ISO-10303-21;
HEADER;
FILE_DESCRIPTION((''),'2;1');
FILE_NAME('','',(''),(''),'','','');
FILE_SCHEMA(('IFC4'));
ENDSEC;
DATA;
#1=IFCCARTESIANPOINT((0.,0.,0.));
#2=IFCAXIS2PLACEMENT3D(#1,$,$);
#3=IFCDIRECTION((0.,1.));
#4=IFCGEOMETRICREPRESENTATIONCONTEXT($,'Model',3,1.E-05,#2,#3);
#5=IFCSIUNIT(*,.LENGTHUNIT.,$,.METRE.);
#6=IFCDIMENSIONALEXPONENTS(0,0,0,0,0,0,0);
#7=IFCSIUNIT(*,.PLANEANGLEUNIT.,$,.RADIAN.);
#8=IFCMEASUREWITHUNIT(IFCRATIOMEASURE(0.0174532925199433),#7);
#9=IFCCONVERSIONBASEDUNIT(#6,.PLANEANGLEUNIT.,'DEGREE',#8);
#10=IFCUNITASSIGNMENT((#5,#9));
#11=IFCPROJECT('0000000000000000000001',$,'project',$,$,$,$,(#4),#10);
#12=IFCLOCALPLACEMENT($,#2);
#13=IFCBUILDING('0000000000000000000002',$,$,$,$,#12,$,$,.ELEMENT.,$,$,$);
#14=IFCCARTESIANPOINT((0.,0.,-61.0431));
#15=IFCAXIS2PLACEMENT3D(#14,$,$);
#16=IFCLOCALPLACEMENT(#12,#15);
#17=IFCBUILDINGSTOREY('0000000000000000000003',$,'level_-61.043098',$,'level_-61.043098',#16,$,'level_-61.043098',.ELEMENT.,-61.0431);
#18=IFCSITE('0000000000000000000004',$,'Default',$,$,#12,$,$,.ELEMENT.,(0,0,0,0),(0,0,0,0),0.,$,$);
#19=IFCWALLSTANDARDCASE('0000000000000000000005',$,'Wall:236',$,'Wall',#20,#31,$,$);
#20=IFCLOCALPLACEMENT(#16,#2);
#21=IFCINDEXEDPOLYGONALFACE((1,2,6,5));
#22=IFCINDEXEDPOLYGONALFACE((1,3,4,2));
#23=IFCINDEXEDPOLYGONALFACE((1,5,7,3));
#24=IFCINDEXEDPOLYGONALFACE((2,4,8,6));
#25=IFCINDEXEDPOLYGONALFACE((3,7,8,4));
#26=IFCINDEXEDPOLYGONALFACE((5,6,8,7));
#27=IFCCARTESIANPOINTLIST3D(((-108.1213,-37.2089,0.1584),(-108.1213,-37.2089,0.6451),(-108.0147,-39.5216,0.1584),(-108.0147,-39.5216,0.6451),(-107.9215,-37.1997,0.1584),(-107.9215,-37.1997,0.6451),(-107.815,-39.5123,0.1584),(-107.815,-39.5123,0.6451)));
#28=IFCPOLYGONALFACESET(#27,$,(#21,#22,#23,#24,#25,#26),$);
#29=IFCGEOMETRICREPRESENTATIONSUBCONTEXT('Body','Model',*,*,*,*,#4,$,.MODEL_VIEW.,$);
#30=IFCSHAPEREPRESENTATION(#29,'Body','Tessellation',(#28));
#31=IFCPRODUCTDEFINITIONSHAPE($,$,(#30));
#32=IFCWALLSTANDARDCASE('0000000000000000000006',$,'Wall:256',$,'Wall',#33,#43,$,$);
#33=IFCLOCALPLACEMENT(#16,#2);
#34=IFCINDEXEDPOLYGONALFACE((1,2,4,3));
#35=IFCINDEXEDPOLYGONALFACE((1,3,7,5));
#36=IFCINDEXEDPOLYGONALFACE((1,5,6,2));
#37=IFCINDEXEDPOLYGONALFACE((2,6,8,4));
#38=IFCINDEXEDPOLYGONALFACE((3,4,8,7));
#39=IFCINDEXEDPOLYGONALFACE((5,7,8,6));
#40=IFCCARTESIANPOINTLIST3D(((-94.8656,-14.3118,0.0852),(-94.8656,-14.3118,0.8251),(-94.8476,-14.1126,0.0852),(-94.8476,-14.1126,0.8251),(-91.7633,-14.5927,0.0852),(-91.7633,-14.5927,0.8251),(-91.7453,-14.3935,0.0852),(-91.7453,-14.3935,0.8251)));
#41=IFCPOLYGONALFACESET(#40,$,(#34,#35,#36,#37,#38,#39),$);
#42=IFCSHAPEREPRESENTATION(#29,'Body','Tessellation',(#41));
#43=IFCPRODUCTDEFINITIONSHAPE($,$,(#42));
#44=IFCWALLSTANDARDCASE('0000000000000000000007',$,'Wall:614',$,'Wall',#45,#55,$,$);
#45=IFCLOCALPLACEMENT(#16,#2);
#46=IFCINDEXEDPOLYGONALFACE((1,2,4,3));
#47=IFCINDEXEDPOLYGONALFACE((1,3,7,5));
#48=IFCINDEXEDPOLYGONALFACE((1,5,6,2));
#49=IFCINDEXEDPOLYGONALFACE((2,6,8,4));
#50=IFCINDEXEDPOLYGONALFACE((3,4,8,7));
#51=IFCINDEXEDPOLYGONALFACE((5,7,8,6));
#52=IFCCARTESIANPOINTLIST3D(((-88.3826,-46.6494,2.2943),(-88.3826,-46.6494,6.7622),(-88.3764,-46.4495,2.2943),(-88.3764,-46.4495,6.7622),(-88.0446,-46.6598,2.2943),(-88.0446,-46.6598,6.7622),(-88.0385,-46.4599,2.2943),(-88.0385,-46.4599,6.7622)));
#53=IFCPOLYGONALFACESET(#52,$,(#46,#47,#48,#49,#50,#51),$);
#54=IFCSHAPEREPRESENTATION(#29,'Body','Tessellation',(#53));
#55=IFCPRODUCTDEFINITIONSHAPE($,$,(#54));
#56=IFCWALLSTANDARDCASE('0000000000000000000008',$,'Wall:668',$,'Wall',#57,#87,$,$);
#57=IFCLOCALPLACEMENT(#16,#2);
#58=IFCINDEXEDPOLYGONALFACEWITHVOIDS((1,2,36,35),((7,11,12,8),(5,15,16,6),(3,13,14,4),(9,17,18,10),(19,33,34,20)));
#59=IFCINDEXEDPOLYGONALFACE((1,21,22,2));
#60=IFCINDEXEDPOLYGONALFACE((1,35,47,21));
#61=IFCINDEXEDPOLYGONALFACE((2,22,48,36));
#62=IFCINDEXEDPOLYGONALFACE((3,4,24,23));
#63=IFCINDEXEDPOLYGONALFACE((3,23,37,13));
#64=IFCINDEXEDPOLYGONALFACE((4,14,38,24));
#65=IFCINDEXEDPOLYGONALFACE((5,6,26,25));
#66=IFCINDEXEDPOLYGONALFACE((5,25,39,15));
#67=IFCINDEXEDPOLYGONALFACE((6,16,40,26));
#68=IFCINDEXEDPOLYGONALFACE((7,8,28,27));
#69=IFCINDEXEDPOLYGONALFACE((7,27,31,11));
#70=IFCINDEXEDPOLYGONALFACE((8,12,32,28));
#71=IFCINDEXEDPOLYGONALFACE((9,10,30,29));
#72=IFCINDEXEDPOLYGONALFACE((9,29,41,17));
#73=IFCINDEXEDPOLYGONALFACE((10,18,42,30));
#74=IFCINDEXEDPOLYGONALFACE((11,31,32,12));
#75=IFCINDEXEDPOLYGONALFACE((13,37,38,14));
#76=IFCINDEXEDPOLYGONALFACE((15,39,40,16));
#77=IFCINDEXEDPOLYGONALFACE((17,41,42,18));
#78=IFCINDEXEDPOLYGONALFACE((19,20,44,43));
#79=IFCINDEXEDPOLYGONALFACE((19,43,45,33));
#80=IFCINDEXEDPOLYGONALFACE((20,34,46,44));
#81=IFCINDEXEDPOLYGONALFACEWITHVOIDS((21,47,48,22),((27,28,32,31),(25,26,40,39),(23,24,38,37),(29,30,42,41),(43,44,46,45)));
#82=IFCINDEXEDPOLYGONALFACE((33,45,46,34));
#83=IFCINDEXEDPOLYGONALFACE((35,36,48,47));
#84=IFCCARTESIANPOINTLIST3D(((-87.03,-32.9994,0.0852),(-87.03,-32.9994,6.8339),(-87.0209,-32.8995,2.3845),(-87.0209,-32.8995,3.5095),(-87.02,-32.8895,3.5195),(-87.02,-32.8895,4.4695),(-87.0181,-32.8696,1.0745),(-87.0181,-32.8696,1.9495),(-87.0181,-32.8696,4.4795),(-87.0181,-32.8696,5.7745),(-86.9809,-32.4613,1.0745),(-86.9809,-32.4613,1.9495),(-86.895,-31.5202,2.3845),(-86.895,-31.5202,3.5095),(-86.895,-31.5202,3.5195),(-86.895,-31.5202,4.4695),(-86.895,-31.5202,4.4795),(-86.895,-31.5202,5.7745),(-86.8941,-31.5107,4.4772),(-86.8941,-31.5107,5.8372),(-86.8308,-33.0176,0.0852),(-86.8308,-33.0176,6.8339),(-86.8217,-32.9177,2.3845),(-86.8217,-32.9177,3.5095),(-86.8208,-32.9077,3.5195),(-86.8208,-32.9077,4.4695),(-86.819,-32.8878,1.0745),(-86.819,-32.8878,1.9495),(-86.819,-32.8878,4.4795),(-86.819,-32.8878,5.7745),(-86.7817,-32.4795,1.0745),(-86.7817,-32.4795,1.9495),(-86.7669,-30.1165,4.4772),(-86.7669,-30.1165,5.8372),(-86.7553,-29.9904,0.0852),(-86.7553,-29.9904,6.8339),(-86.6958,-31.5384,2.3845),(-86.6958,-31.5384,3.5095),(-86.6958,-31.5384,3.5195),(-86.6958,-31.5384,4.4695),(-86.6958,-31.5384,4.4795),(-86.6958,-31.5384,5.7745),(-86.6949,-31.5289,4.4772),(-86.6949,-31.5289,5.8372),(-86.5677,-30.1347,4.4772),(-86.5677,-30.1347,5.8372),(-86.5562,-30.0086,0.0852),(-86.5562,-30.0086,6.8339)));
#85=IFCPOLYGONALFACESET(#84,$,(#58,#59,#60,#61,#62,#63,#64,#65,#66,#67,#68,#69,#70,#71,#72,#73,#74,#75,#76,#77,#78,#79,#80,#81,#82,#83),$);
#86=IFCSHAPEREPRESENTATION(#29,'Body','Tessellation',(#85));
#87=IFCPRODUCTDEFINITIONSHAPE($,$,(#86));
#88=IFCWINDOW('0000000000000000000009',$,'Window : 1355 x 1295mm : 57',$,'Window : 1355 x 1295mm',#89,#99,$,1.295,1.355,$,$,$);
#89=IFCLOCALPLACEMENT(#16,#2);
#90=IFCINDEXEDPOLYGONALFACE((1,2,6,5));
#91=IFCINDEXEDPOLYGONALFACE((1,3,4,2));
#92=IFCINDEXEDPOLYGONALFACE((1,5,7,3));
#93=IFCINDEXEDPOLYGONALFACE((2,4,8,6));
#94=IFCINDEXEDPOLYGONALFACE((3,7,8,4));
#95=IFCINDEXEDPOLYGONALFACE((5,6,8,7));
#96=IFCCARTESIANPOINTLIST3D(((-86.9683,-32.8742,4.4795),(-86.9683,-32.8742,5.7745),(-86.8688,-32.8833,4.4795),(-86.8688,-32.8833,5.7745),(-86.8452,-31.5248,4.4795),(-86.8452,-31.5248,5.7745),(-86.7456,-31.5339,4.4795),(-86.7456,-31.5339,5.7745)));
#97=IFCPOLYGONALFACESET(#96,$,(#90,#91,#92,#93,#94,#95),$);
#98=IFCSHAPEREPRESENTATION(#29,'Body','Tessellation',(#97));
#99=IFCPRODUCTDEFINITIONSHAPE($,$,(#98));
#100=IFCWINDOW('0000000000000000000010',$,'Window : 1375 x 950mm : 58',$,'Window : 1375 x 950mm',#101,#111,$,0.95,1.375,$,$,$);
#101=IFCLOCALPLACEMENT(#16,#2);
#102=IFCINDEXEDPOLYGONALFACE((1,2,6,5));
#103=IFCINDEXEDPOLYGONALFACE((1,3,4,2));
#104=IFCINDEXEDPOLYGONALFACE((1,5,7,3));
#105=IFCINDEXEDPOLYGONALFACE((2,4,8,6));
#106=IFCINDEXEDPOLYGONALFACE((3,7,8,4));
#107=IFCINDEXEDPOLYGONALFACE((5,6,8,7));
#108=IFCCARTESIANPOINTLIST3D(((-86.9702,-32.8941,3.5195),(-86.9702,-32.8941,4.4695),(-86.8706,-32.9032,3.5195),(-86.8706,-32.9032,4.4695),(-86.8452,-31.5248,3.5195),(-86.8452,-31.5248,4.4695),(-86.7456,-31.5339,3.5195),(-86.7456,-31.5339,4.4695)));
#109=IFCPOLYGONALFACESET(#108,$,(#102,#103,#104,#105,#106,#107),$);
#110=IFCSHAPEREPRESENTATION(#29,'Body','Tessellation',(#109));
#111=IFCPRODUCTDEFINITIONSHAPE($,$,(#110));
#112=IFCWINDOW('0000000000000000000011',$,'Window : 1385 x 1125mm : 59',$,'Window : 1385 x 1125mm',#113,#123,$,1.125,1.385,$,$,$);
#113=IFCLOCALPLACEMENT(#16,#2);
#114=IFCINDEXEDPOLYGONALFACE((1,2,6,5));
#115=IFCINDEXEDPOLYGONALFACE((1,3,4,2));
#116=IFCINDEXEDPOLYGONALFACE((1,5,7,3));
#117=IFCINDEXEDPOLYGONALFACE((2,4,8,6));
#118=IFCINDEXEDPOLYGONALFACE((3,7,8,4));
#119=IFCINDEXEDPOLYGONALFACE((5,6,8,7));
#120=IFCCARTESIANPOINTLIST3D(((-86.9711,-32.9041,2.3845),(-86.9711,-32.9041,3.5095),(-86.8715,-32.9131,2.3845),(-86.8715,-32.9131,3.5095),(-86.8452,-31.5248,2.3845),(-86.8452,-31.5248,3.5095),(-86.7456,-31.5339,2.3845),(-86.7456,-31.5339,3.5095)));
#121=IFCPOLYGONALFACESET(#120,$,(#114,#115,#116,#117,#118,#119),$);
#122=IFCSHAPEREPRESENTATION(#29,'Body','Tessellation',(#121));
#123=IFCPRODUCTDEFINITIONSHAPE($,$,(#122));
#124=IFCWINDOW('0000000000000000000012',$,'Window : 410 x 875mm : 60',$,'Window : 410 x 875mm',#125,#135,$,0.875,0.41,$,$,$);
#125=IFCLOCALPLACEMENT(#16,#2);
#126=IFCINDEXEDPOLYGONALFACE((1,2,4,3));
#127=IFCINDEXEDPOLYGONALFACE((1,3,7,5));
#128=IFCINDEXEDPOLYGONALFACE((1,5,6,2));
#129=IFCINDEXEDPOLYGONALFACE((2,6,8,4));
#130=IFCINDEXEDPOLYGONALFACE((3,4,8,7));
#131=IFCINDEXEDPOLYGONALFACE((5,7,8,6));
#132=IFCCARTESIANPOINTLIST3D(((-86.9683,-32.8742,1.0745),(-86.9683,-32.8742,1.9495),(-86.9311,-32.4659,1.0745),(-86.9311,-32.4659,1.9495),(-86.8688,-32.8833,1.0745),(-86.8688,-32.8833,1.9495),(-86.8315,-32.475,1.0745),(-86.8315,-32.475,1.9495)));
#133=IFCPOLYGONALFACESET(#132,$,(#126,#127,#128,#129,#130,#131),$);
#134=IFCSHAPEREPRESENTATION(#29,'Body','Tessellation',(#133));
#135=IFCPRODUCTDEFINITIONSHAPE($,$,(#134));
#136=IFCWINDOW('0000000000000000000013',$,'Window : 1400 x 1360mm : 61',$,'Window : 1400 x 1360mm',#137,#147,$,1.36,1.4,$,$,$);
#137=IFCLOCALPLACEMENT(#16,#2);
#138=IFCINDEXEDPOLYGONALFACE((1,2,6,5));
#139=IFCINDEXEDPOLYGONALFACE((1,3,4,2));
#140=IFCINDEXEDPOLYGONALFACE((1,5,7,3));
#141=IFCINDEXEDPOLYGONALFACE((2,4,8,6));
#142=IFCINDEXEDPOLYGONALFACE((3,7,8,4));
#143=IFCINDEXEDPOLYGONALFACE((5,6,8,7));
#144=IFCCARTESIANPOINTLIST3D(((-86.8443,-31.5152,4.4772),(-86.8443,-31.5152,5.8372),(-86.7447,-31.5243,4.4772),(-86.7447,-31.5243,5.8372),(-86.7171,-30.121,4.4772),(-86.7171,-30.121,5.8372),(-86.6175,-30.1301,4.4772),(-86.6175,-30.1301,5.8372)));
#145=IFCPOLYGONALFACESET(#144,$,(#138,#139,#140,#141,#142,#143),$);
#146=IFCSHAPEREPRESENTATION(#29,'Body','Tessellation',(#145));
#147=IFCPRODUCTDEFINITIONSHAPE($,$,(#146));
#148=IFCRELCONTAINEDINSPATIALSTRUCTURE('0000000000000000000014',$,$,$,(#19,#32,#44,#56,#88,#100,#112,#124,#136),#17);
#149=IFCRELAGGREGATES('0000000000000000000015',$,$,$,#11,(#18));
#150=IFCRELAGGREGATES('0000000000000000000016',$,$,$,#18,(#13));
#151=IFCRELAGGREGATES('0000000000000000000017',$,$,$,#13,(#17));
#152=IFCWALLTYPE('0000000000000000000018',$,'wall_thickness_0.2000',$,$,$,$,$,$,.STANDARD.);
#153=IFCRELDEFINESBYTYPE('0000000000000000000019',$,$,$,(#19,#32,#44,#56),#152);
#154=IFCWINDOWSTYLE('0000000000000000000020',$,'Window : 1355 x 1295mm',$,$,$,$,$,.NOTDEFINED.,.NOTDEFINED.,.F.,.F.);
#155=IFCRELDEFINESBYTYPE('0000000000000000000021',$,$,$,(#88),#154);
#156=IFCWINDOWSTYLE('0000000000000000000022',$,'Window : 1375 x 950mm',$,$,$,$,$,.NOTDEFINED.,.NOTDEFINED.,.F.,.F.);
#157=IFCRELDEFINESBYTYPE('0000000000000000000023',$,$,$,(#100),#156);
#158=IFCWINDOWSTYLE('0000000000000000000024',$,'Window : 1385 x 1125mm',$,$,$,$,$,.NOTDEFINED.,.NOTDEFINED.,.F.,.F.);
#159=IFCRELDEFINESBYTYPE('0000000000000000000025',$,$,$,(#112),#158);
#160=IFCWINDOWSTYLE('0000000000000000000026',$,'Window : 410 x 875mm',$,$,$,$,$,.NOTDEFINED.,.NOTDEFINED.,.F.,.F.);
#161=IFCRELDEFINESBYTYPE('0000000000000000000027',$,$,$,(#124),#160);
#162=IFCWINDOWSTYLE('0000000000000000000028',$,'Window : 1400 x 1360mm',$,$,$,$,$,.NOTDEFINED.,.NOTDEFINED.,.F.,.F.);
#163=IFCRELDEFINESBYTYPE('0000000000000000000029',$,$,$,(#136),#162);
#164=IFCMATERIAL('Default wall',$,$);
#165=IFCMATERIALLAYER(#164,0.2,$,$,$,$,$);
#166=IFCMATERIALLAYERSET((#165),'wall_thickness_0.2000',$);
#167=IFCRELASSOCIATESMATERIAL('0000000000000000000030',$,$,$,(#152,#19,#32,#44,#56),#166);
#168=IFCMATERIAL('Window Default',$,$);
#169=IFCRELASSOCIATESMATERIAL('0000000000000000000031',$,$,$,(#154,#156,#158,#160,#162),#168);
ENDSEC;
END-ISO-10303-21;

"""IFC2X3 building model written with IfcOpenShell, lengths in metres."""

from ifc_helpers import new_model, entity, si_unit, converted_unit, direction, frame, frame_2d, origin, origin_2d_with_axis, place, context, subcontext, project, spatial, polyline, rectangle, outline, extrude, source, transform, mapped, material, layer, layer_set, layer_usage, type_object, type_shapes, element, fill, save


model = new_model("IFC2X3")

# Units and contexts
model_context = context("Model", 3, precision=1e-05, world=origin(), true_north=direction((0.0, 1.0)))
body_context = subcontext(model_context, "Body", "Model", "MODEL_VIEW")
ifc_project = project(units=[si_unit("LENGTHUNIT", "METRE"), converted_unit("PLANEANGLEUNIT", "DEGREE", entity("IfcRatioMeasure", 0.0174532925199433), si_unit("PLANEANGLEUNIT", "RADIAN"), dimensions=[0, 0, 0, 0, 0, 0, 0])], contexts=[model_context])

# Site, building, storey
placement_1 = place(None, origin())
site = spatial("IfcSite", under=ifc_project, at=placement_1, Name="Default", CompositionType="ELEMENT", RefLatitude=(0, 0, 0, 0), RefLongitude=(0, 0, 0, 0), RefElevation=0.0)
building = spatial("IfcBuilding", under=site, at=placement_1, CompositionType="ELEMENT")
storey_placement = place(placement_1, frame((0.0, 0.0, -61.0431)))
storey = spatial("IfcBuildingStorey", under=building, at=storey_placement, Name="level_-61.043098", ObjectType="level_-61.043098", LongName="level_-61.043098", CompositionType="ELEMENT", Elevation=-61.0431)

# Walls
ifc_material_1 = material(Name="Default wall")
ifc_layer = layer(ifc_material_1, 0.2)
ifc_layer_set = layer_set([ifc_layer], Name="wall_thickness_0.2000")
ifc_layer_usage = layer_usage(ifc_layer_set, "AXIS2", "POSITIVE", -0.1)
wall_type = type_object("IfcWallType", Name="wall_thickness_0.2000", PredefinedType="STANDARD", material=ifc_layer_set)
placement_2 = place(placement_1, frame((0.0, 0.0, -60.8847)))
wall_1_placement = place(placement_2, frame((-108.0214, -37.2043, 0.0), z_axis=(0.0, 0.0, 1.0), x_axis=(0.046035, -0.99894, 0.0)))
element("IfcWallStandardCase", 1, at=wall_1_placement, inside=storey, type_object=wall_type, material=ifc_layer_usage, Name="Wall:236", ObjectType="Wall", context=body_context, shape_type="SweptSolid", body=[
    extrude(outline(polyline([(2.3151, -0.1), (2.3151, 0.1), (0.0, 0.1), (0.0, -0.1), (2.3151, -0.1)])), origin(), (0.0, 0.0, 1.0), 0.4867),
])
placement_3 = place(placement_1, frame((0.0, 0.0, -60.9579)))
wall_2_placement = place(placement_3, frame((-94.8566, -14.2122, 0.0), z_axis=(0.0, 0.0, 1.0), x_axis=(0.995927, -0.090165, 0.0)))
element("IfcWallStandardCase", 2, at=wall_2_placement, inside=storey, type_object=wall_type, material=ifc_layer_usage, Name="Wall:256", ObjectType="Wall", context=body_context, shape_type="SweptSolid", body=[
    extrude(outline(polyline([(3.115, -0.1), (3.115, 0.1), (0.0, 0.1), (0.0, -0.1), (3.115, -0.1)])), origin(), (0.0, 0.0, 1.0), 0.7399),
])
placement_4 = place(placement_1, frame((0.0, 0.0, -58.7488)))
wall_3_placement = place(placement_4, frame((-88.0415, -46.5599, 0.0), z_axis=(0.0, 0.0, 1.0), x_axis=(-0.999523, 0.030892, 0.0)))
element("IfcWallStandardCase", 3, at=wall_3_placement, inside=storey, type_object=wall_type, material=ifc_layer_usage, Name="Wall:614", ObjectType="Wall", context=body_context, shape_type="SweptSolid", body=[
    extrude(outline(polyline([(0.3381, -0.1), (0.3381, 0.1), (0.0, 0.1), (0.0, -0.1), (0.3381, -0.1)])), origin(), (0.0, 0.0, 1.0), 4.4679),
])

# Wall, openings, windows
placement_5 = place(placement_1, frame((0.0, 0.0, -60.9579)))
wall_4_placement = place(placement_5, frame((-86.6558, -29.9995, 0.0), z_axis=(0.0, 0.0, 1.0), x_axis=(-0.090893, -0.995861, 0.0)))
wall_4 = element("IfcWallStandardCase", 4, at=wall_4_placement, inside=storey, type_object=wall_type, material=ifc_layer_usage, Name="Wall:668", ObjectType="Wall", context=body_context, shape_type="SweptSolid", body=[
    extrude(outline(polyline([(3.0215, -0.1), (3.0215, 0.1), (0.0, 0.1), (0.0, -0.1), (3.0215, -0.1)])), origin(), (0.0, 0.0, 1.0), 6.7487),
])
opening_1_placement = place(wall_4_placement, frame((1.5362, -0.1, 4.3942)))
opening_1 = element("IfcOpeningElement", 5, at=opening_1_placement, cuts=wall_4, ObjectType="Opening", context=body_context, shape_type="SweptSolid", body=[
    extrude(rectangle(XDim=1.355, YDim=1.295, at=frame_2d((0.6475, 0.6775), x_axis=(0.0, 1.0))), frame((0.0, 0.0, 0.0), z_axis=(0.0, 1.0, 0.0), x_axis=(0.0, 0.0, 1.0)), (0.0, 0.0, 1.0), 0.2),
])
opening_2_placement = place(wall_4_placement, frame((1.5362, -0.1, 3.4342)))
opening_2 = element("IfcOpeningElement", 6, at=opening_2_placement, cuts=wall_4, ObjectType="Opening", context=body_context, shape_type="SweptSolid", body=[
    extrude(rectangle(XDim=1.375, YDim=0.95, at=frame_2d((0.475, 0.6875), x_axis=(0.0, 1.0))), frame((0.0, 0.0, 0.0), z_axis=(0.0, 1.0, 0.0), x_axis=(0.0, 0.0, 1.0)), (0.0, 0.0, 1.0), 0.2),
])
opening_3_placement = place(wall_4_placement, frame((1.5362, -0.1, 2.2992)))
opening_3 = element("IfcOpeningElement", 7, at=opening_3_placement, cuts=wall_4, ObjectType="Opening", context=body_context, shape_type="SweptSolid", body=[
    extrude(rectangle(XDim=1.385, YDim=1.125, at=frame_2d((0.5625, 0.6925), x_axis=(0.0, 1.0))), frame((0.0, 0.0, 0.0), z_axis=(0.0, 1.0, 0.0), x_axis=(0.0, 0.0, 1.0)), (0.0, 0.0, 1.0), 0.2),
])
opening_4_placement = place(wall_4_placement, frame((2.4812, -0.1, 0.9892)))
opening_4 = element("IfcOpeningElement", 8, at=opening_4_placement, cuts=wall_4, ObjectType="Opening", context=body_context, shape_type="SweptSolid", body=[
    extrude(rectangle(XDim=0.41, YDim=0.875, at=frame_2d((0.4375, 0.205), x_axis=(0.0, 1.0))), frame((0.0, 0.0, 0.0), z_axis=(0.0, 1.0, 0.0), x_axis=(0.0, 0.0, 1.0)), (0.0, 0.0, 1.0), 0.2),
])
opening_5_placement = place(wall_4_placement, frame((0.1266, -0.1, 4.392)))
opening_5 = element("IfcOpeningElement", 9, at=opening_5_placement, cuts=wall_4, ObjectType="Opening", context=body_context, shape_type="SweptSolid", body=[
    extrude(rectangle(XDim=1.4, YDim=1.36, at=frame_2d((0.68, 0.7), x_axis=(0.0, 1.0))), frame((0.0, 0.0, 0.0), z_axis=(0.0, 1.0, 0.0), x_axis=(0.0, 0.0, 1.0)), (0.0, 0.0, 1.0), 0.2),
])
ifc_material_2 = material(Name="Window Default")
window_style_1 = type_object("IfcWindowStyle", Name="Window : 1355 x 1295mm", ConstructionType="NOTDEFINED", OperationType="NOTDEFINED", ParameterTakesPrecedence=False, Sizeable=False, material=ifc_material_2)
shared_shape_1 = source(origin(), body_context, "Body", "SweptSolid", [
    extrude(rectangle(XDim=0.1, YDim=1.355, at=origin_2d_with_axis()), frame((0.6775, 0.1, 0.0), z_axis=(0.0, 0.0, 1.0), x_axis=(0.0, 1.0, 0.0)), (0.0, 0.0, 1.0), 1.295),
])
type_shapes(window_style_1, [shared_shape_1])
window_1_placement = place(opening_1_placement, origin())
window_1 = element("IfcWindow", 10, at=window_1_placement, inside=storey, type_object=window_style_1, Name="Window : 1355 x 1295mm : 57", ObjectType="Window : 1355 x 1295mm", OverallHeight=1.295, OverallWidth=1.355, context=body_context, shape_type="MappedRepresentation", body=[
    mapped(shared_shape_1, transform((0.0, 0.0, 0.0), scale=1.0)),
])
fill(opening_1, window_1)
window_style_2 = type_object("IfcWindowStyle", Name="Window : 1375 x 950mm", ConstructionType="NOTDEFINED", OperationType="NOTDEFINED", ParameterTakesPrecedence=False, Sizeable=False, material=ifc_material_2)
shared_shape_2 = source(origin(), body_context, "Body", "SweptSolid", [
    extrude(rectangle(XDim=0.1, YDim=1.375, at=origin_2d_with_axis()), frame((0.6875, 0.1, 0.0), z_axis=(0.0, 0.0, 1.0), x_axis=(0.0, 1.0, 0.0)), (0.0, 0.0, 1.0), 0.95),
])
type_shapes(window_style_2, [shared_shape_2])
window_2_placement = place(opening_2_placement, origin())
window_2 = element("IfcWindow", 11, at=window_2_placement, inside=storey, type_object=window_style_2, Name="Window : 1375 x 950mm : 58", ObjectType="Window : 1375 x 950mm", OverallHeight=0.95, OverallWidth=1.375, context=body_context, shape_type="MappedRepresentation", body=[
    mapped(shared_shape_2, transform((0.0, 0.0, 0.0), scale=1.0)),
])
fill(opening_2, window_2)
window_style_3 = type_object("IfcWindowStyle", Name="Window : 1385 x 1125mm", ConstructionType="NOTDEFINED", OperationType="NOTDEFINED", ParameterTakesPrecedence=False, Sizeable=False, material=ifc_material_2)
shared_shape_3 = source(origin(), body_context, "Body", "SweptSolid", [
    extrude(rectangle(XDim=0.1, YDim=1.385, at=origin_2d_with_axis()), frame((0.6925, 0.1, 0.0), z_axis=(0.0, 0.0, 1.0), x_axis=(0.0, 1.0, 0.0)), (0.0, 0.0, 1.0), 1.125),
])
type_shapes(window_style_3, [shared_shape_3])
window_3_placement = place(opening_3_placement, origin())
window_3 = element("IfcWindow", 12, at=window_3_placement, inside=storey, type_object=window_style_3, Name="Window : 1385 x 1125mm : 59", ObjectType="Window : 1385 x 1125mm", OverallHeight=1.125, OverallWidth=1.385, context=body_context, shape_type="MappedRepresentation", body=[
    mapped(shared_shape_3, transform((0.0, 0.0, 0.0), scale=1.0)),
])
fill(opening_3, window_3)
window_style_4 = type_object("IfcWindowStyle", Name="Window : 410 x 875mm", ConstructionType="NOTDEFINED", OperationType="NOTDEFINED", ParameterTakesPrecedence=False, Sizeable=False, material=ifc_material_2)
shared_shape_4 = source(origin(), body_context, "Body", "SweptSolid", [
    extrude(rectangle(XDim=0.1, YDim=0.41, at=origin_2d_with_axis()), frame((0.205, 0.1, 0.0), z_axis=(0.0, 0.0, 1.0), x_axis=(0.0, 1.0, 0.0)), (0.0, 0.0, 1.0), 0.875),
])
type_shapes(window_style_4, [shared_shape_4])
window_4_placement = place(opening_4_placement, origin())
window_4 = element("IfcWindow", 13, at=window_4_placement, inside=storey, type_object=window_style_4, Name="Window : 410 x 875mm : 60", ObjectType="Window : 410 x 875mm", OverallHeight=0.875, OverallWidth=0.41, context=body_context, shape_type="MappedRepresentation", body=[
    mapped(shared_shape_4, transform((0.0, 0.0, 0.0), scale=1.0)),
])
fill(opening_4, window_4)
window_style_5 = type_object("IfcWindowStyle", Name="Window : 1400 x 1360mm", ConstructionType="NOTDEFINED", OperationType="NOTDEFINED", ParameterTakesPrecedence=False, Sizeable=False, material=ifc_material_2)
shared_shape_5 = source(origin(), body_context, "Body", "SweptSolid", [
    extrude(rectangle(XDim=0.1, YDim=1.4, at=origin_2d_with_axis()), frame((0.7, 0.1, 0.0), z_axis=(0.0, 0.0, 1.0), x_axis=(0.0, 1.0, 0.0)), (0.0, 0.0, 1.0), 1.36),
])
type_shapes(window_style_5, [shared_shape_5])
window_5_placement = place(opening_5_placement, origin())
window_5 = element("IfcWindow", 14, at=window_5_placement, inside=storey, type_object=window_style_5, Name="Window : 1400 x 1360mm : 61", ObjectType="Window : 1400 x 1360mm", OverallHeight=1.36, OverallWidth=1.4, context=body_context, shape_type="MappedRepresentation", body=[
    mapped(shared_shape_5, transform((0.0, 0.0, 0.0), scale=1.0)),
])
fill(opening_5, window_5)

save(model, "model.ifc")
